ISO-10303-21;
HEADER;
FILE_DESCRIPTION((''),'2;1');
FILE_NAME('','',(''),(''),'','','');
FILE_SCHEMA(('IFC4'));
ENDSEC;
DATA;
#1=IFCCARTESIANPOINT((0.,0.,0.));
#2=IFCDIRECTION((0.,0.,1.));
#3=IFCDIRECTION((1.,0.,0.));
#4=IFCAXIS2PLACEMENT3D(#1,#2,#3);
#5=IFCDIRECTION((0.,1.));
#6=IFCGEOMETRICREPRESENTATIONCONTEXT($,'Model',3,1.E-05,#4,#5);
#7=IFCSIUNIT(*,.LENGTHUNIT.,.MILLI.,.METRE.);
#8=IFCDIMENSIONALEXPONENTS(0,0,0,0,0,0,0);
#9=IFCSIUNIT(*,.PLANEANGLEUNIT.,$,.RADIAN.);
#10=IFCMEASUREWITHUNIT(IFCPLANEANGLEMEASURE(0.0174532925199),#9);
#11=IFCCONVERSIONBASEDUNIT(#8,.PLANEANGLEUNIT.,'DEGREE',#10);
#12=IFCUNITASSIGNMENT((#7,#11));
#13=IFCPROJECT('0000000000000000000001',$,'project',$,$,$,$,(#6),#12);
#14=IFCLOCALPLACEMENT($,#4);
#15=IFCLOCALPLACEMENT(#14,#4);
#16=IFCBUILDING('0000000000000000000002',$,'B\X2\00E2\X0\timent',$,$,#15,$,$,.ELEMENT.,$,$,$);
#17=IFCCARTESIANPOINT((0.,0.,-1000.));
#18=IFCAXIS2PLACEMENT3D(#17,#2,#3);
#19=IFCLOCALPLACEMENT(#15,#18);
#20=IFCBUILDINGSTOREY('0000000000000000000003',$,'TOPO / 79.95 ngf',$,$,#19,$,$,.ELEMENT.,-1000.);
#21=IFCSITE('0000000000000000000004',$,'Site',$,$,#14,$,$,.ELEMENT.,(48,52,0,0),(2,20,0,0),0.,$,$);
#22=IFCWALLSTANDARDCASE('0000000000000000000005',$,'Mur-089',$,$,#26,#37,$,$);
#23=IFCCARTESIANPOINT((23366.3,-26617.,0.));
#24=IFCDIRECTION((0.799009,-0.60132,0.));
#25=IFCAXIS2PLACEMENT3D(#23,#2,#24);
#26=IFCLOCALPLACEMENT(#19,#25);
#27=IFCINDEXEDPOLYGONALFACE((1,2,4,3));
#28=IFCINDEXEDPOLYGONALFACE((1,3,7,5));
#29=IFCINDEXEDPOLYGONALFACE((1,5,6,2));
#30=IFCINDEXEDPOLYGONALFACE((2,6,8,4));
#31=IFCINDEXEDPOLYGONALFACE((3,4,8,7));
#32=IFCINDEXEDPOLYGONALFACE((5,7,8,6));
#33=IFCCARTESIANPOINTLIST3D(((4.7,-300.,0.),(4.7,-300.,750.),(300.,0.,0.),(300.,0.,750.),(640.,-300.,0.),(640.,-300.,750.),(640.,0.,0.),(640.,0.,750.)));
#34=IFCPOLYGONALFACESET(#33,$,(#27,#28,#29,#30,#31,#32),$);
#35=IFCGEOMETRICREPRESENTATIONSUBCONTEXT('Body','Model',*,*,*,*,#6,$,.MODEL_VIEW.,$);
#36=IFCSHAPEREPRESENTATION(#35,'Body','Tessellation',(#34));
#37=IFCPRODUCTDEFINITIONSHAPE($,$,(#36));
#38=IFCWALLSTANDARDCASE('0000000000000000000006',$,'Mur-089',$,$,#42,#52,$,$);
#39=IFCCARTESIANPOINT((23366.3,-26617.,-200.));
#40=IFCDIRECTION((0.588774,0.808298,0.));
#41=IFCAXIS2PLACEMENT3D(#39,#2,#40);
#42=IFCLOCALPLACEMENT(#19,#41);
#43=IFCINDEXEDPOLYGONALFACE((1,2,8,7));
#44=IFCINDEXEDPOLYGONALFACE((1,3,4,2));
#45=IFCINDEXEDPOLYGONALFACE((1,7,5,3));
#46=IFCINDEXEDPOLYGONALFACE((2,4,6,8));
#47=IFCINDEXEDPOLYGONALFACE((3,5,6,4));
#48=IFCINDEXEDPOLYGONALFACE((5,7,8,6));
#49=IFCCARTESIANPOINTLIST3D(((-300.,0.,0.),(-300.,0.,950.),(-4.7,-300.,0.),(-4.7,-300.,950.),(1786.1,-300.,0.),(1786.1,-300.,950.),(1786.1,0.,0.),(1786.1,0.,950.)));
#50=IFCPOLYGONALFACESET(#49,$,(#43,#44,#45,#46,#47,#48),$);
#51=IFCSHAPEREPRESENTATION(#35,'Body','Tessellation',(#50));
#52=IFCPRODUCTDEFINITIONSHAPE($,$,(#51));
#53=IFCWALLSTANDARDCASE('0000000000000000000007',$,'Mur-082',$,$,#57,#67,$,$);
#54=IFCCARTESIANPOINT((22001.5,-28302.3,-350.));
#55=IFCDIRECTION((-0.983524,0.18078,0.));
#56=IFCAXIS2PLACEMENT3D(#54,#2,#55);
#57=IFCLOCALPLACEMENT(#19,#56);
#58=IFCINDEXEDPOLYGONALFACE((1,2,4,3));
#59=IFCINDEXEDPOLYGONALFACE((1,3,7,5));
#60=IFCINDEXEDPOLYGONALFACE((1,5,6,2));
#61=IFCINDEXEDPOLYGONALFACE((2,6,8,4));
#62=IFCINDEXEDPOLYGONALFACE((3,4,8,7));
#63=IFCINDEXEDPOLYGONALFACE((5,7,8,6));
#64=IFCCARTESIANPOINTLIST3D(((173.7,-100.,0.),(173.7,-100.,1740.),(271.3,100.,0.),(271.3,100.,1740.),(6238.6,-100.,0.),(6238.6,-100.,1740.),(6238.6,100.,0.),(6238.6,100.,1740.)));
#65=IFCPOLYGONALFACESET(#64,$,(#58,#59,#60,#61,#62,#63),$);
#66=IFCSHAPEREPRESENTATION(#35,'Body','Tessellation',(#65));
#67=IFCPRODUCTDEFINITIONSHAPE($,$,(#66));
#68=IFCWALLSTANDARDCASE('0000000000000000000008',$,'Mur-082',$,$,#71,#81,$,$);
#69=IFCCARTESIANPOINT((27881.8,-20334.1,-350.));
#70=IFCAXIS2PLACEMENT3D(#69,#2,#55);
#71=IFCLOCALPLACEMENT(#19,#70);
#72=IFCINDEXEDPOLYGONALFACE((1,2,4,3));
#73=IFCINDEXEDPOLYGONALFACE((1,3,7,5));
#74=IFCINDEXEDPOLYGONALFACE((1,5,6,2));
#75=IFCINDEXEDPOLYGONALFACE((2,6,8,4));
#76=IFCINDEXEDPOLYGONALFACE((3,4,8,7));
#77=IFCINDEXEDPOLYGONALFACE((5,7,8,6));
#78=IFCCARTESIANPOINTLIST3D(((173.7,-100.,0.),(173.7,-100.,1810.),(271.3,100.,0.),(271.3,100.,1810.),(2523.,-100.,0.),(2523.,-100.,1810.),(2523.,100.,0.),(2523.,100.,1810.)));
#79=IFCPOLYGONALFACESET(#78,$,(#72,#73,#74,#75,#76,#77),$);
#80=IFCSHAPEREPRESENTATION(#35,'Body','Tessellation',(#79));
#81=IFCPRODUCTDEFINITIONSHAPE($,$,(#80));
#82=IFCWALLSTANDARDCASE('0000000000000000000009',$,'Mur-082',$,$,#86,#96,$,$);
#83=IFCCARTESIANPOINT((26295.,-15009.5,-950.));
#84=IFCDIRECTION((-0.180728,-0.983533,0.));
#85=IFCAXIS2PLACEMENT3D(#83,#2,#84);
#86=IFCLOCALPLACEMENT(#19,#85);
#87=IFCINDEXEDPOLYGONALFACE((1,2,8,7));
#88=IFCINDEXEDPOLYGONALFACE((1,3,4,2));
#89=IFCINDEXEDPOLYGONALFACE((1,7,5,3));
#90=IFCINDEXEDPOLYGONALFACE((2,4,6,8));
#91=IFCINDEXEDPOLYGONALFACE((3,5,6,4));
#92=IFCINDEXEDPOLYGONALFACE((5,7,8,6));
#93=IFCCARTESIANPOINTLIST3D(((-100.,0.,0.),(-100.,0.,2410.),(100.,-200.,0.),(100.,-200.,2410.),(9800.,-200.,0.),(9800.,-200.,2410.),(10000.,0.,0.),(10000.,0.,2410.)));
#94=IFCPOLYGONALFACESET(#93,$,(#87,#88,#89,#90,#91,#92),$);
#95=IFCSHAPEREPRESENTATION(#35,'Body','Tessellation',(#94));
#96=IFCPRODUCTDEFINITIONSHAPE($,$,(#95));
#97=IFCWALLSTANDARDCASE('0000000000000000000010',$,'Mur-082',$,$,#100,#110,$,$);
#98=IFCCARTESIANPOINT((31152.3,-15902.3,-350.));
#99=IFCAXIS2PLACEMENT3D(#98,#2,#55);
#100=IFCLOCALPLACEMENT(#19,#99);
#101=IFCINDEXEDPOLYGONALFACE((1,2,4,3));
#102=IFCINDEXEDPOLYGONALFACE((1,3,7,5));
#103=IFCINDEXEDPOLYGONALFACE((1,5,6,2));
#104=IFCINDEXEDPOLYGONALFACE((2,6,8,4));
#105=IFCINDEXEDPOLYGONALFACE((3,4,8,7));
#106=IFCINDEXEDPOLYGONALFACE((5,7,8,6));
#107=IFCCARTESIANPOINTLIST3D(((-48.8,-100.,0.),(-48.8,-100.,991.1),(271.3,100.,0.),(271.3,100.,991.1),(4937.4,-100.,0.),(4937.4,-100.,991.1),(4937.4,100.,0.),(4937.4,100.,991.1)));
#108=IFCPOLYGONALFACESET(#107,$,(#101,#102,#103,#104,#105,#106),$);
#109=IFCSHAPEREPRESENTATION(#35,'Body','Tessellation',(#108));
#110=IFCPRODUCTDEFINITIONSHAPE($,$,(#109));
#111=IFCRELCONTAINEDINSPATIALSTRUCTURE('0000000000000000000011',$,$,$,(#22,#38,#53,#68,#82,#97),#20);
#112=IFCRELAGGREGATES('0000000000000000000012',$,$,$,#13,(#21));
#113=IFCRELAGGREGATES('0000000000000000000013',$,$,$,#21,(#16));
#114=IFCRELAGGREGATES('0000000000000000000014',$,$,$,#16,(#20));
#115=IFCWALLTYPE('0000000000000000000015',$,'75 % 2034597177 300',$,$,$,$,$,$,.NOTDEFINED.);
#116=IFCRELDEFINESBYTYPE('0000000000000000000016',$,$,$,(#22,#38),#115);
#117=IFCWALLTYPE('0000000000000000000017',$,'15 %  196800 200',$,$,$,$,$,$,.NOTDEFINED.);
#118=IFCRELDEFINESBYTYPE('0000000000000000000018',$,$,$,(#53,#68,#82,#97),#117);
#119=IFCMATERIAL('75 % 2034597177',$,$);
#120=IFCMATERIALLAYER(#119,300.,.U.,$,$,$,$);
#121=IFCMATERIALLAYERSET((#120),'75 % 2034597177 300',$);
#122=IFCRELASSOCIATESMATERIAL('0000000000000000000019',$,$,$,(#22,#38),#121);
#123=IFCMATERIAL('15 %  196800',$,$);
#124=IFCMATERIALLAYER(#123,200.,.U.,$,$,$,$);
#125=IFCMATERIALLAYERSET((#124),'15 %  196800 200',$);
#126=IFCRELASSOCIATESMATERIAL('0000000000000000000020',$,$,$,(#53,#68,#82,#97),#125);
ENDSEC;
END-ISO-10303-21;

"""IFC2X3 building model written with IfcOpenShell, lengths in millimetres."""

from ifc_helpers import new_model, entity, si_unit, converted_unit, direction, frame, origin_with_axes, place, context, subcontext, project, spatial, polyline, outline, extrude, material, layer, layer_set, layer_usage, type_object, element, save


model = new_model("IFC2X3")

# Units and contexts
model_context = context("Model", 3, precision=1e-05, world=origin_with_axes(), true_north=direction((0.0, 1.0)))
body_context = subcontext(model_context, "Body", "Model", "MODEL_VIEW")
ifc_project = project(units=[si_unit("LENGTHUNIT", "METRE", prefix="MILLI"), converted_unit("PLANEANGLEUNIT", "DEGREE", entity("IfcPlaneAngleMeasure", 0.0174532925199), si_unit("PLANEANGLEUNIT", "RADIAN"), dimensions=[0, 0, 0, 0, 0, 0, 0])], contexts=[model_context])

# Site, building, storey
site_placement = place(None, origin_with_axes())
site = spatial("IfcSite", under=ifc_project, at=site_placement, Name="Site", CompositionType="ELEMENT", RefLatitude=(48, 52, 0, 0), RefLongitude=(2, 20, 0, 0), RefElevation=0.0)
building_placement = place(site_placement, origin_with_axes())
building = spatial("IfcBuilding", under=site, at=building_placement, Name="Bâtiment", CompositionType="ELEMENT")
storey_placement = place(building_placement, frame((0.0, 0.0, -1000.0), z_axis=(0.0, 0.0, 1.0), x_axis=(1.0, 0.0, 0.0)))
storey = spatial("IfcBuildingStorey", under=building, at=storey_placement, Name="TOPO / 79.95 ngf", CompositionType="ELEMENT", Elevation=-1000.0)

# Walls
ifc_material_1 = material(Name="75 % 2034597177")
ifc_layer_1 = layer(ifc_material_1, 300.0, ventilated="UNKNOWN")
ifc_layer_set_1 = layer_set([ifc_layer_1], Name="75 % 2034597177 300")
wall_type_1 = type_object("IfcWallType", Name="75 % 2034597177 300", PredefinedType="NOTDEFINED")
ifc_layer_usage_1 = layer_usage(ifc_layer_set_1, "AXIS2", "POSITIVE", -300.0)
wall_1_placement = place(storey_placement, frame((23366.3, -26617.0, 0.0), z_axis=(0.0, 0.0, 1.0), x_axis=(0.799009, -0.60132, 0.0)))
element("IfcWallStandardCase", 1, at=wall_1_placement, inside=storey, type_object=wall_type_1, material=ifc_layer_usage_1, Name="Mur-089", context=body_context, shape_type="SweptSolid", body=[
    extrude(outline(polyline([(4.7, -300.0), (640.0, -300.0), (640.0, 0.0), (300.0, 0.0), (4.7, -300.0)])), origin_with_axes(), (0.0, 0.0, 1.0), 750.0),
])
ifc_layer_usage_2 = layer_usage(ifc_layer_set_1, "AXIS2", "POSITIVE", -300.0)
wall_2_placement = place(storey_placement, frame((23366.3, -26617.0, -200.0), z_axis=(0.0, 0.0, 1.0), x_axis=(0.588774, 0.808298, 0.0)))
element("IfcWallStandardCase", 2, at=wall_2_placement, inside=storey, type_object=wall_type_1, material=ifc_layer_usage_2, Name="Mur-089", context=body_context, shape_type="SweptSolid", body=[
    extrude(outline(polyline([(-4.7, -300.0), (1786.1, -300.0), (1786.1, 0.0), (-300.0, 0.0), (-4.7, -300.0)])), origin_with_axes(), (0.0, 0.0, 1.0), 950.0),
])
ifc_material_2 = material(Name="15 %  196800")
ifc_layer_2 = layer(ifc_material_2, 200.0, ventilated="UNKNOWN")
ifc_layer_set_2 = layer_set([ifc_layer_2], Name="15 %  196800 200")
wall_type_2 = type_object("IfcWallType", Name="15 %  196800 200", PredefinedType="NOTDEFINED")
ifc_layer_usage_3 = layer_usage(ifc_layer_set_2, "AXIS2", "NEGATIVE", 100.0)
wall_3_placement = place(storey_placement, frame((22001.5, -28302.3, -350.0), z_axis=(0.0, 0.0, 1.0), x_axis=(-0.983524, 0.18078, 0.0)))
element("IfcWallStandardCase", 3, at=wall_3_placement, inside=storey, type_object=wall_type_2, material=ifc_layer_usage_3, Name="Mur-082", context=body_context, shape_type="SweptSolid", body=[
    extrude(outline(polyline([(173.7, -100.0), (6238.6, -100.0), (6238.6, 100.0), (271.3, 100.0), (173.7, -100.0)])), origin_with_axes(), (0.0, 0.0, 1.0), 1740.0),
])
ifc_layer_usage_4 = layer_usage(ifc_layer_set_2, "AXIS2", "NEGATIVE", 100.0)
wall_4_placement = place(storey_placement, frame((27881.8, -20334.1, -350.0), z_axis=(0.0, 0.0, 1.0), x_axis=(-0.983524, 0.18078, 0.0)))
element("IfcWallStandardCase", 4, at=wall_4_placement, inside=storey, type_object=wall_type_2, material=ifc_layer_usage_4, Name="Mur-082", context=body_context, shape_type="SweptSolid", body=[
    extrude(outline(polyline([(173.7, -100.0), (2523.0, -100.0), (2523.0, 100.0), (271.3, 100.0), (173.7, -100.0)])), origin_with_axes(), (0.0, 0.0, 1.0), 1810.0),
])
ifc_layer_usage_5 = layer_usage(ifc_layer_set_2, "AXIS2", "NEGATIVE", 0.0)
wall_5_placement = place(storey_placement, frame((26295.0, -15009.5, -950.0), z_axis=(0.0, 0.0, 1.0), x_axis=(-0.180728, -0.983533, 0.0)))
element("IfcWallStandardCase", 5, at=wall_5_placement, inside=storey, type_object=wall_type_2, material=ifc_layer_usage_5, Name="Mur-082", context=body_context, shape_type="SweptSolid", body=[
    extrude(outline(polyline([(100.0, -200.0), (9800.0, -200.0), (10000.0, 0.0), (-100.0, 0.0), (100.0, -200.0)])), origin_with_axes(), (0.0, 0.0, 1.0), 2410.0),
])
ifc_layer_usage_6 = layer_usage(ifc_layer_set_2, "AXIS2", "NEGATIVE", 100.0)
wall_6_placement = place(storey_placement, frame((31152.3, -15902.3, -350.0), z_axis=(0.0, 0.0, 1.0), x_axis=(-0.983524, 0.18078, 0.0)))
element("IfcWallStandardCase", 6, at=wall_6_placement, inside=storey, type_object=wall_type_2, material=ifc_layer_usage_6, Name="Mur-082", context=body_context, shape_type="SweptSolid", body=[
    extrude(outline(polyline([(-48.8, -100.0), (4937.4, -100.0), (4937.4, 100.0), (271.3, 100.0), (-48.8, -100.0)])), origin_with_axes(), (0.0, 0.0, 1.0), 991.1),
])

save(model, "model.ifc")
